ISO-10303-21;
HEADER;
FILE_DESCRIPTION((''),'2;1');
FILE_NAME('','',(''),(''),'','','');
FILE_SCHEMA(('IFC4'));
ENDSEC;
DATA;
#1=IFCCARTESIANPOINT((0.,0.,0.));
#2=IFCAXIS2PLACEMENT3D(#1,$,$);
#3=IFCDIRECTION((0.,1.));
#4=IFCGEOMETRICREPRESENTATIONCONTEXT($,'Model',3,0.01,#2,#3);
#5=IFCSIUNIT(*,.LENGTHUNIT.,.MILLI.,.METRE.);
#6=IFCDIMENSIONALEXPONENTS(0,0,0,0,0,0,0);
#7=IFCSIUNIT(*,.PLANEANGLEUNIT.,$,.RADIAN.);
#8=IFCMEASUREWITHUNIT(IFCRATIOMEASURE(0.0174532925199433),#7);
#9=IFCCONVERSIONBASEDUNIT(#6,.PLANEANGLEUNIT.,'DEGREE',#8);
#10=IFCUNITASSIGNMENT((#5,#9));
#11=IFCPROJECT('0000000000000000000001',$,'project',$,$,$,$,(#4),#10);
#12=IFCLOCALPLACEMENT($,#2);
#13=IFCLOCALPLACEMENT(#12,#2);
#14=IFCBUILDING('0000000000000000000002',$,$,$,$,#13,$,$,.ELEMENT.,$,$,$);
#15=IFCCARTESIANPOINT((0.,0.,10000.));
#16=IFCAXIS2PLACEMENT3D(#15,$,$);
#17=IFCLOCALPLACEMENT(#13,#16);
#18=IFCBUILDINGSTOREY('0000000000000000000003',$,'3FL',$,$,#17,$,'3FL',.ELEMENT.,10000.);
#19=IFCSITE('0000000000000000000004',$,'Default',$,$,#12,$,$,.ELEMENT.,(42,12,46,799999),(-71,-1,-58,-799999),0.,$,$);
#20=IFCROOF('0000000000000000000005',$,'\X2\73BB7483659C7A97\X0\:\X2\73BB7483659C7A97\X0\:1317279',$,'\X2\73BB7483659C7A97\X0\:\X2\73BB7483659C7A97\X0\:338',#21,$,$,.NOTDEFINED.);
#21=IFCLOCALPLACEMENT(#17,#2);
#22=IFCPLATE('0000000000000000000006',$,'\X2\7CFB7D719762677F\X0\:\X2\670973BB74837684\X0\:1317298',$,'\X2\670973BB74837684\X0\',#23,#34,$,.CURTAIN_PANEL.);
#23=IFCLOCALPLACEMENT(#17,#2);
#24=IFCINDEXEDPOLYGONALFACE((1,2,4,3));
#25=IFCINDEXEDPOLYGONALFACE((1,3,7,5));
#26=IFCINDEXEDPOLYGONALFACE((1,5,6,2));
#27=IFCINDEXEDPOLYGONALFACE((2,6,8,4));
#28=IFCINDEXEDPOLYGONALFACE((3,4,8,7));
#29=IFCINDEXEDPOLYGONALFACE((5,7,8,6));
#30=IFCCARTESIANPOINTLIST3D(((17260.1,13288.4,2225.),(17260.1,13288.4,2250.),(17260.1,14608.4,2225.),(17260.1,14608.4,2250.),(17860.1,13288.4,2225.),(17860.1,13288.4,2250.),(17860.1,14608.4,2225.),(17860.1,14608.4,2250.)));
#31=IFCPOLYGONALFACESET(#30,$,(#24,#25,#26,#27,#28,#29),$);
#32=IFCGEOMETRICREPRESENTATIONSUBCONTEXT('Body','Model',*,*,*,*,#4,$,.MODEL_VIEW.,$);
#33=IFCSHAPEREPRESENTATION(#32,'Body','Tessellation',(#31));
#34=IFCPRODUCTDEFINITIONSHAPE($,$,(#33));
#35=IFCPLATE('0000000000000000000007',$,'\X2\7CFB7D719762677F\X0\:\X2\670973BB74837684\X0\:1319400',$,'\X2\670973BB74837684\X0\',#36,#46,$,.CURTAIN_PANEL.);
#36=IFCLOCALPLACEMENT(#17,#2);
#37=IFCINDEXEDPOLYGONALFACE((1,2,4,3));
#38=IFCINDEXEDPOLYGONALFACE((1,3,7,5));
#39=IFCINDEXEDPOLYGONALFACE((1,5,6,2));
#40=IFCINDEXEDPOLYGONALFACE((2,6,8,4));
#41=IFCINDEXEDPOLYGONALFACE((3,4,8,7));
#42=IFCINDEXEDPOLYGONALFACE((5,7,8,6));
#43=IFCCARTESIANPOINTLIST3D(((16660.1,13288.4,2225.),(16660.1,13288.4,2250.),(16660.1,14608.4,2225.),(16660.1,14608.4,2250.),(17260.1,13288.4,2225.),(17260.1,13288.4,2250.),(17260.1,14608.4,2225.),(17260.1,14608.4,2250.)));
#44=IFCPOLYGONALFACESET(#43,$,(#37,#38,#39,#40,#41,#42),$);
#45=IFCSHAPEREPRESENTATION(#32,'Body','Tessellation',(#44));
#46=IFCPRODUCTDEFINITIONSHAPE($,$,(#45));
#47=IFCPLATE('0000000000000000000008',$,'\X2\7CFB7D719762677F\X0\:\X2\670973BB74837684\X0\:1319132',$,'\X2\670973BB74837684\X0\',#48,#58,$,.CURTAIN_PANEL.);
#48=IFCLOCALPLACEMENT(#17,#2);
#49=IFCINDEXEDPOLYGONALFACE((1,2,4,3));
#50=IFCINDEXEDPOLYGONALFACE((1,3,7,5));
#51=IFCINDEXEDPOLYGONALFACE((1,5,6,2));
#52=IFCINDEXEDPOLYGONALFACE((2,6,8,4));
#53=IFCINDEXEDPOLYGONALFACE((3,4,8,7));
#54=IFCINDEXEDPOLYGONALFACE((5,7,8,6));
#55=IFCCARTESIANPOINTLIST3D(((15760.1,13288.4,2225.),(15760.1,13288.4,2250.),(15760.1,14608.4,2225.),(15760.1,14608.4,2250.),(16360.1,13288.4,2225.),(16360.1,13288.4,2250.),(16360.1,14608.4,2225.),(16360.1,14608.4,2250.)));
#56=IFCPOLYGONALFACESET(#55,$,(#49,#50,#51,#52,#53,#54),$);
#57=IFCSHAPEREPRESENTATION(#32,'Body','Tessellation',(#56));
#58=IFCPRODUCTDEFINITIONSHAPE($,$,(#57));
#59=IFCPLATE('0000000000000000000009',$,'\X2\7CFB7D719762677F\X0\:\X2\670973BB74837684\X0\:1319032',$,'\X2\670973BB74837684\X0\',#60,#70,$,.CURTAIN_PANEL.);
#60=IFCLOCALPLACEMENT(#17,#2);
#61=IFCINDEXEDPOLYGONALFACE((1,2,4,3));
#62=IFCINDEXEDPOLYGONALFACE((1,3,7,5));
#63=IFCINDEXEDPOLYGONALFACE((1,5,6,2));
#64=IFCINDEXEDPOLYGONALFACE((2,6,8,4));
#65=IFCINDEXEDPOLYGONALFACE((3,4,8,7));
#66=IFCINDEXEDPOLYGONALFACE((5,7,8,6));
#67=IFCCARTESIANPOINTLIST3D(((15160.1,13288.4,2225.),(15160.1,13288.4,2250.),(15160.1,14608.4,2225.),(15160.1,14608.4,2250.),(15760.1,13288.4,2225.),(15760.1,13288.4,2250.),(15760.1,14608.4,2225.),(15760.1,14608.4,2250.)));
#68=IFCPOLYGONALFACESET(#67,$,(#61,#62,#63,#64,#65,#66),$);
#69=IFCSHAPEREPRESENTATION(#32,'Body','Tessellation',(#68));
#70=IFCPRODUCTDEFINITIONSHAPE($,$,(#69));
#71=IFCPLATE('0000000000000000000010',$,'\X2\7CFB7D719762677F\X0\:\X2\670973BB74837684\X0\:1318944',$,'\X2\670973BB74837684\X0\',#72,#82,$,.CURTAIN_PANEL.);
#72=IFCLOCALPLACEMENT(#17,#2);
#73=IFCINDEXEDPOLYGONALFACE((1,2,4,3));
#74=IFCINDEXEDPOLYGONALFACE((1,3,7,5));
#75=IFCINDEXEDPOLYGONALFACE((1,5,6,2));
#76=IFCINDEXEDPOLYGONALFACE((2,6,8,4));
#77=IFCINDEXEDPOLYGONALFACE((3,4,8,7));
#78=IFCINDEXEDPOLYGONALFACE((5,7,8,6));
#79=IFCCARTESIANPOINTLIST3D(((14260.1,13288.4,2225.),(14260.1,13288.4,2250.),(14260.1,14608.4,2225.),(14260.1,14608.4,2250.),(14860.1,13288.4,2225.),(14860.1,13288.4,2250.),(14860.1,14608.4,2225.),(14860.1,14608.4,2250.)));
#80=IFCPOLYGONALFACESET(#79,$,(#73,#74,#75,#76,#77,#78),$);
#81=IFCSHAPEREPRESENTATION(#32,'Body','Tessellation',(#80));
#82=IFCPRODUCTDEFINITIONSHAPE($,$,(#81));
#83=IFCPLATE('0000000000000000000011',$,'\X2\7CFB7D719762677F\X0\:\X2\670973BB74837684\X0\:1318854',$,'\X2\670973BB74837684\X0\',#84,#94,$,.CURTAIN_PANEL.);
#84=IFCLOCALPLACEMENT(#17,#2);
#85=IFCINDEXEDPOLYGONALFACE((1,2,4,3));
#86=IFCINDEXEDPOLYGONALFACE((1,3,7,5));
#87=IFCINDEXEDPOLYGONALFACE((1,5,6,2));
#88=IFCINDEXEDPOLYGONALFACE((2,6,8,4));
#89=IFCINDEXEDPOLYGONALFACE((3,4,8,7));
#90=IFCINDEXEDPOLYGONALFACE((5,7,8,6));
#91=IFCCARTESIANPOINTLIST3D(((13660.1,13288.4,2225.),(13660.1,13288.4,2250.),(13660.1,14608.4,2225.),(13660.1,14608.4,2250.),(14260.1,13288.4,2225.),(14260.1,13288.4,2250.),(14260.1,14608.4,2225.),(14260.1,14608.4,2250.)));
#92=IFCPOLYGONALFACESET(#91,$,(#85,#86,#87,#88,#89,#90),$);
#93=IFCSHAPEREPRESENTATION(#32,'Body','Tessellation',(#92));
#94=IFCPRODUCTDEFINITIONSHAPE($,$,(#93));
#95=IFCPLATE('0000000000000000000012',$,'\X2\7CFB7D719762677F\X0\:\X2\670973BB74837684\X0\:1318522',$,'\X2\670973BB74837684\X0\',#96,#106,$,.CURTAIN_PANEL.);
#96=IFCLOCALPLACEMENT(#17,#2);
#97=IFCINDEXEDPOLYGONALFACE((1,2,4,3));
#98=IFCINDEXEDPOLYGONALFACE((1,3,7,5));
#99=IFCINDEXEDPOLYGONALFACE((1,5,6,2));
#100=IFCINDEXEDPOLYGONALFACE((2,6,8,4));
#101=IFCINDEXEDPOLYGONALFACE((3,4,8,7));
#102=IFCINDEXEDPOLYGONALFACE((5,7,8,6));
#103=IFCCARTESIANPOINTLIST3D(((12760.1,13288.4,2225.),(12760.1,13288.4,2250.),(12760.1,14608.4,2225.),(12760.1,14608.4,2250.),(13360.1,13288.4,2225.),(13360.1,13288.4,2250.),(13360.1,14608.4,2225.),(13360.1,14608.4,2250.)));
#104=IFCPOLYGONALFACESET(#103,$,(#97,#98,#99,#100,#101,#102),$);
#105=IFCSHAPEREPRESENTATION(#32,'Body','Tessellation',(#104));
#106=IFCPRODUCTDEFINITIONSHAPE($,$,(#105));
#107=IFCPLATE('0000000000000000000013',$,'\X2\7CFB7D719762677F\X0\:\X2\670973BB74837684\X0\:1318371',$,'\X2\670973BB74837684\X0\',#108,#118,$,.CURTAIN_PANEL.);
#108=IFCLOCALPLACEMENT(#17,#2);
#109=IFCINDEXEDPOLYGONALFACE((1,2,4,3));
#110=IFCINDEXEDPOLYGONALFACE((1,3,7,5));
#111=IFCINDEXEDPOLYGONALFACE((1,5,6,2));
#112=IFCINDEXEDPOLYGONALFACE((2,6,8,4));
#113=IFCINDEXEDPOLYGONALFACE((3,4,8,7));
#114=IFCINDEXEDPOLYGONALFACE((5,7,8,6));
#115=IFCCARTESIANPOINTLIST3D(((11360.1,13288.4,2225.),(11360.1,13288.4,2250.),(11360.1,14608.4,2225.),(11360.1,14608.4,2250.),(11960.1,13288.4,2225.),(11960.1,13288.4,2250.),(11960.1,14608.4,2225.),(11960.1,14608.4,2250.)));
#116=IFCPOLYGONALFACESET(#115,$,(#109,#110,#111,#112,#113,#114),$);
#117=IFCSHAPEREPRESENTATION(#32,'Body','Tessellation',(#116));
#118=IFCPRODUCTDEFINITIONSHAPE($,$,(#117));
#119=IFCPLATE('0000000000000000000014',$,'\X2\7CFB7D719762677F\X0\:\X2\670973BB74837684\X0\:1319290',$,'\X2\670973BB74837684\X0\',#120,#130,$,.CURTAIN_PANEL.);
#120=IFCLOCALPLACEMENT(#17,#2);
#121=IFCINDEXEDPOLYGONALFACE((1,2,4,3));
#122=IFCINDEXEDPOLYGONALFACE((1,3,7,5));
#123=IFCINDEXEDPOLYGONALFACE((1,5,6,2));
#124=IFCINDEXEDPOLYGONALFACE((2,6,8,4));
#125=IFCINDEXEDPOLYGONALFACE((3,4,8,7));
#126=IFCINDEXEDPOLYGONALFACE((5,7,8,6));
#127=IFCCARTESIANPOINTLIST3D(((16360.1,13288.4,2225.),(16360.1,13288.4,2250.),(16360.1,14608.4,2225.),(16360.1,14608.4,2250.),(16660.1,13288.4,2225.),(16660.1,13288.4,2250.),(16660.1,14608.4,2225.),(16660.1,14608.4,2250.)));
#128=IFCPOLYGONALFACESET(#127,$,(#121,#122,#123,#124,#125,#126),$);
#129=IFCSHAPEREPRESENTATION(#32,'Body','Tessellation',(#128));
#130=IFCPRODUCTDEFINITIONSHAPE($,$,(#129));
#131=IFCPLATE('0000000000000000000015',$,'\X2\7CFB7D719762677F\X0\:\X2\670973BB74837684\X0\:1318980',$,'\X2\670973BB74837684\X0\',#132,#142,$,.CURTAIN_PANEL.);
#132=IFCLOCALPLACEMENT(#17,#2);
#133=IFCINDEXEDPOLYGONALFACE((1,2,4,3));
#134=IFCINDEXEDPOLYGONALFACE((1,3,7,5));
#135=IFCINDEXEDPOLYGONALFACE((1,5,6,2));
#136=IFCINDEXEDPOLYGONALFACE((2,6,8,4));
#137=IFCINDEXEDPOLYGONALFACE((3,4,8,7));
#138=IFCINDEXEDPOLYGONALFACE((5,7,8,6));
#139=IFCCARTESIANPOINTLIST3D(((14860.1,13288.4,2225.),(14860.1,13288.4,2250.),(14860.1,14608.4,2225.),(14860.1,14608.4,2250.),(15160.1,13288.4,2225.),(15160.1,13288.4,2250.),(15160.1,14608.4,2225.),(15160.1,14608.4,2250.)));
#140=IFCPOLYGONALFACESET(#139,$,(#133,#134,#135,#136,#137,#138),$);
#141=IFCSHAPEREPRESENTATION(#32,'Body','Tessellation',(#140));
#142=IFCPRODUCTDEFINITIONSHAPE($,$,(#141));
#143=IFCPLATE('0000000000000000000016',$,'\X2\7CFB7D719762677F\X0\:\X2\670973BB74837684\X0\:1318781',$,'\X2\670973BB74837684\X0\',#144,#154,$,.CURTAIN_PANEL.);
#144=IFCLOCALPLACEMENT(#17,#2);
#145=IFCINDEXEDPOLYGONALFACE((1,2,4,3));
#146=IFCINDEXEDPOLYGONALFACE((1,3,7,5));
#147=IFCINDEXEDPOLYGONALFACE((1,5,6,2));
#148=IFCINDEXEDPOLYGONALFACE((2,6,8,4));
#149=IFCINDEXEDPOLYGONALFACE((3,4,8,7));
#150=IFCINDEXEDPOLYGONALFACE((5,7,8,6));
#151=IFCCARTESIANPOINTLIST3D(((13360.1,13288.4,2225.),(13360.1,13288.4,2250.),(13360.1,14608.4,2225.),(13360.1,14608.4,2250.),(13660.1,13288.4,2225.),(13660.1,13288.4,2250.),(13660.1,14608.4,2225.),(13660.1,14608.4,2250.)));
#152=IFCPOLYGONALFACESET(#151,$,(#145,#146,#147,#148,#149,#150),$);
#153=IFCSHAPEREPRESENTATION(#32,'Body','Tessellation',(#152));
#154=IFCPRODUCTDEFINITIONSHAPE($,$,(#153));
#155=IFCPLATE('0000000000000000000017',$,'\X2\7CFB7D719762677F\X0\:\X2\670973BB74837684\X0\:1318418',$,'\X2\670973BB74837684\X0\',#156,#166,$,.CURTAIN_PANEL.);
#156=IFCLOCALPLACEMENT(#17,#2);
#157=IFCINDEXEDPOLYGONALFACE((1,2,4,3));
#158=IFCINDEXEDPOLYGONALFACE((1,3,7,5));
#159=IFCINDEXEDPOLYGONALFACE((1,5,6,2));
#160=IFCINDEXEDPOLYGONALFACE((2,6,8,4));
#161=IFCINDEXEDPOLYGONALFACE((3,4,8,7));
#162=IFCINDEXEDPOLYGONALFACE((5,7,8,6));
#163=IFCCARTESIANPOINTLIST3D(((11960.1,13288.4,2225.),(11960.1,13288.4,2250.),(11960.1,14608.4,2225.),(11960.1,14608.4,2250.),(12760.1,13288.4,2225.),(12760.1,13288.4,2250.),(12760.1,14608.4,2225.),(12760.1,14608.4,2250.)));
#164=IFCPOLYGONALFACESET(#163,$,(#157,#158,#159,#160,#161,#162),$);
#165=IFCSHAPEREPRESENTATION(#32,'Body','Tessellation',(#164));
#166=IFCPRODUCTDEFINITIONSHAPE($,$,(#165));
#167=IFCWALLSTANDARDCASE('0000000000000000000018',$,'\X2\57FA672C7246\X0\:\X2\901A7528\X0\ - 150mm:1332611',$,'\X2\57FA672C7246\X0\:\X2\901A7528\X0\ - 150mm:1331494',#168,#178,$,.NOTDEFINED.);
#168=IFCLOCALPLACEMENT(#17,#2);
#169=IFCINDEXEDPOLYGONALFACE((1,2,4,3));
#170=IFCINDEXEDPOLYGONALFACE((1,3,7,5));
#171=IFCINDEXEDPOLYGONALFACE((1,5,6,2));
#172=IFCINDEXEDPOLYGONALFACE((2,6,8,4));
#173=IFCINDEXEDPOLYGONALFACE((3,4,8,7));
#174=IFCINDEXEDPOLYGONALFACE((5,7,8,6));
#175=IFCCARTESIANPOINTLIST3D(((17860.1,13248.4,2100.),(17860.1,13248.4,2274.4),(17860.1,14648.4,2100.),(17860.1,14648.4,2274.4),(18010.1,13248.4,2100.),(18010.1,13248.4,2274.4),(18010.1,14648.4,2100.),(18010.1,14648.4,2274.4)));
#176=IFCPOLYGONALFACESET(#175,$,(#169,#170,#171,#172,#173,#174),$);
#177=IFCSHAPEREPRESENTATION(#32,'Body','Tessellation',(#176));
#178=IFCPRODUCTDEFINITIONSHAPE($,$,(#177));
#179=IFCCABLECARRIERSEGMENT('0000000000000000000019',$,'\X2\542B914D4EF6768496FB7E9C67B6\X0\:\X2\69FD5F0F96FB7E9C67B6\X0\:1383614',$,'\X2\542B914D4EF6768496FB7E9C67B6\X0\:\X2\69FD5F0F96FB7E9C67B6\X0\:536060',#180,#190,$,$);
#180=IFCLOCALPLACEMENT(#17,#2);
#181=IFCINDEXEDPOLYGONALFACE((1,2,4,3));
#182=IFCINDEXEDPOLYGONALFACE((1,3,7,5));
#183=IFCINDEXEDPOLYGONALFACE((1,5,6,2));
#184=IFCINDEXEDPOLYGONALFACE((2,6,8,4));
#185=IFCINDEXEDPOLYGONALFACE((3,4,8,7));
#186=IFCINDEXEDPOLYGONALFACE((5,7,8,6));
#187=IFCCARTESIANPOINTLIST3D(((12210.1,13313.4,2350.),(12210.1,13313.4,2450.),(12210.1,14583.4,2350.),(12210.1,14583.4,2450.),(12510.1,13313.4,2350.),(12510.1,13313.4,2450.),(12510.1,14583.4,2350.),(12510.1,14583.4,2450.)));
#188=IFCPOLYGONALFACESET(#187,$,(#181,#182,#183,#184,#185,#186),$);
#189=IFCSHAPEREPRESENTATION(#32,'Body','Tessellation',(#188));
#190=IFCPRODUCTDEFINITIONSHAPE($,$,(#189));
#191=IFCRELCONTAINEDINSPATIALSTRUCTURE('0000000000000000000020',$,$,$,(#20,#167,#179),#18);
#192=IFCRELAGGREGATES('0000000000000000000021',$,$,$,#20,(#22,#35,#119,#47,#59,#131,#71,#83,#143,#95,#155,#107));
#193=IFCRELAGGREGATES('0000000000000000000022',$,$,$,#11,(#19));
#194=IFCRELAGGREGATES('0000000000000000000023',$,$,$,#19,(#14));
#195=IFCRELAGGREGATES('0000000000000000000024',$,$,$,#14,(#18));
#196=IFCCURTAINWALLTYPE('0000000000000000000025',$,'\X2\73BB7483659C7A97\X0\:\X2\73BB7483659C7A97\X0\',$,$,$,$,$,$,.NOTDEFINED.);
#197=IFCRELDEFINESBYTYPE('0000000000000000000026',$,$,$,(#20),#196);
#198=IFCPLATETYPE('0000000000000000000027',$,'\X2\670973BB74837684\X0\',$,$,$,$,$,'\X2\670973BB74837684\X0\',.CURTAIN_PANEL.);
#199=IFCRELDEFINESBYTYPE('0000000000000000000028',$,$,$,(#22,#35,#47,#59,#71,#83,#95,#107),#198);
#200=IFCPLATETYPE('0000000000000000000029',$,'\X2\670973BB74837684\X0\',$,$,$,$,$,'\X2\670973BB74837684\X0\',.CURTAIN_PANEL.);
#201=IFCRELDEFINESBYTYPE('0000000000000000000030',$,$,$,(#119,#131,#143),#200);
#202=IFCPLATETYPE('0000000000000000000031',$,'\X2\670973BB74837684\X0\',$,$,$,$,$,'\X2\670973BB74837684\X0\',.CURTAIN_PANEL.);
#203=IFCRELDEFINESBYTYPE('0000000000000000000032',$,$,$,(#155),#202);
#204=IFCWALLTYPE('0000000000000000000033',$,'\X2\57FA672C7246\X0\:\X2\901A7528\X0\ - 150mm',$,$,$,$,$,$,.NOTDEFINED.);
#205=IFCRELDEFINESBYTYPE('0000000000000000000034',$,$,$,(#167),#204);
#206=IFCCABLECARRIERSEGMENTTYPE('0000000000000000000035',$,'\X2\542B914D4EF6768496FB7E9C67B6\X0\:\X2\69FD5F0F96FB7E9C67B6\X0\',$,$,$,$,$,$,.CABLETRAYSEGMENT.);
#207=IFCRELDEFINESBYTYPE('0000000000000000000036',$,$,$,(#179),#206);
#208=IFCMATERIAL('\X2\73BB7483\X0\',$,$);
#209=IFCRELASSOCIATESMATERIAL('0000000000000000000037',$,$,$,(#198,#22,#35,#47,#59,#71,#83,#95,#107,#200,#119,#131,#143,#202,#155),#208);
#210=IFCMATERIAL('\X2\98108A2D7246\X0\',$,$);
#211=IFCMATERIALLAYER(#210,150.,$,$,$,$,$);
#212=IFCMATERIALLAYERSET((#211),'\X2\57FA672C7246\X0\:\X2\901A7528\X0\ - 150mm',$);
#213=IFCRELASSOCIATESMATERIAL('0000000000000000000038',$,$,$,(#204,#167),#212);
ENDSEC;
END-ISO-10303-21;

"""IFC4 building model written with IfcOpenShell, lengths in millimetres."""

from ifc_helpers import new_model, entity, si_unit, converted_unit, direction, frame, frame_2d, origin, origin_2d_with_axis, place, context, subcontext, project, spatial, rectangle, extrude, source, transform, mapped, material, layer, layer_set, layer_usage, type_object, type_shapes, element, aggregate, save


model = new_model("IFC4")

# Units and contexts
model_context = context("Model", 3, precision=0.01, world=origin(), true_north=direction((0.0, 1.0)))
body_context = subcontext(model_context, "Body", "Model", "MODEL_VIEW")
ifc_project = project(units=[si_unit("LENGTHUNIT", "METRE", prefix="MILLI"), converted_unit("PLANEANGLEUNIT", "DEGREE", entity("IfcRatioMeasure", 0.0174532925199433), si_unit("PLANEANGLEUNIT", "RADIAN"), dimensions=[0, 0, 0, 0, 0, 0, 0])], contexts=[model_context])

# Site, building, storey
site_placement = place(None, origin())
site = spatial("IfcSite", under=ifc_project, at=site_placement, Name="Default", CompositionType="ELEMENT", RefLatitude=(42, 12, 46, 799999), RefLongitude=(-71, -1, -58, -799999), RefElevation=0.0)
building_placement = place(site_placement, origin())
building = spatial("IfcBuilding", under=site, at=building_placement, CompositionType="ELEMENT")
storey_placement = place(building_placement, frame((0.0, 0.0, 10000.0)))
storey = spatial("IfcBuildingStorey", under=building, at=storey_placement, Name="3FL", LongName="3FL", CompositionType="ELEMENT", Elevation=10000.0)

# Roof, plates
curtain_wall_type = type_object("IfcCurtainWallType", Name="玻璃斜窗:玻璃斜窗", PredefinedType="NOTDEFINED")
roof_placement = place(storey_placement, frame((0.0, 0.0, -10000.0)))
roof = element("IfcRoof", 1, at=roof_placement, inside=storey, type_object=curtain_wall_type, Name="玻璃斜窗:玻璃斜窗:1317279", ObjectType="玻璃斜窗:玻璃斜窗:338", PredefinedType="NOTDEFINED")
ifc_material_1 = material(Name="玻璃")
plate_type_1 = type_object("IfcPlateType", Name="有玻璃的", ElementType="有玻璃的", PredefinedType="CURTAIN_PANEL", material=ifc_material_1)
shared_shape_1 = source(origin(), body_context, "Body", "SweptSolid", [
    extrude(rectangle(XDim=25.0, YDim=600.0, at=origin_2d_with_axis()), frame((300.0, 12.5, 0.0), z_axis=(0.0, 0.0, 1.0), x_axis=(0.0, 1.0, 0.0)), (0.0, 0.0, 1.0), 1320.0),
])
type_shapes(plate_type_1, [shared_shape_1])
plate_1_placement = place(roof_placement, frame((17860.1, 14608.4, 12250.0), z_axis=(0.0, -1.0, 0.0), x_axis=(-1.0, 0.0, 0.0)))
plate_1 = element("IfcPlate", 2, at=plate_1_placement, type_object=plate_type_1, material=ifc_material_1, Name="系統面板:有玻璃的:1317298", ObjectType="有玻璃的", PredefinedType="CURTAIN_PANEL", context=body_context, shape_type="MappedRepresentation", body=[
    mapped(shared_shape_1, transform((0.0, 0.0, 0.0), scale=1.0)),
])
plate_2_placement = place(roof_placement, frame((17260.1, 14608.4, 12250.0), z_axis=(0.0, -1.0, 0.0), x_axis=(-1.0, 0.0, 0.0)))
plate_2 = element("IfcPlate", 3, at=plate_2_placement, type_object=plate_type_1, material=ifc_material_1, Name="系統面板:有玻璃的:1319400", ObjectType="有玻璃的", PredefinedType="CURTAIN_PANEL", context=body_context, shape_type="MappedRepresentation", body=[
    mapped(shared_shape_1, transform((0.0, 0.0, 0.0), scale=1.0)),
])
plate_3_placement = place(roof_placement, frame((16360.1, 14608.4, 12250.0), z_axis=(0.0, -1.0, 0.0), x_axis=(-1.0, 0.0, 0.0)))
plate_3 = element("IfcPlate", 4, at=plate_3_placement, type_object=plate_type_1, material=ifc_material_1, Name="系統面板:有玻璃的:1319132", ObjectType="有玻璃的", PredefinedType="CURTAIN_PANEL", context=body_context, shape_type="MappedRepresentation", body=[
    mapped(shared_shape_1, transform((0.0, 0.0, 0.0), scale=1.0)),
])
plate_4_placement = place(roof_placement, frame((15760.1, 14608.4, 12250.0), z_axis=(0.0, -1.0, 0.0), x_axis=(-1.0, 0.0, 0.0)))
plate_4 = element("IfcPlate", 5, at=plate_4_placement, type_object=plate_type_1, material=ifc_material_1, Name="系統面板:有玻璃的:1319032", ObjectType="有玻璃的", PredefinedType="CURTAIN_PANEL", context=body_context, shape_type="MappedRepresentation", body=[
    mapped(shared_shape_1, transform((0.0, 0.0, 0.0), scale=1.0)),
])
plate_5_placement = place(roof_placement, frame((14860.1, 14608.4, 12250.0), z_axis=(0.0, -1.0, 0.0), x_axis=(-1.0, 0.0, 0.0)))
plate_5 = element("IfcPlate", 6, at=plate_5_placement, type_object=plate_type_1, material=ifc_material_1, Name="系統面板:有玻璃的:1318944", ObjectType="有玻璃的", PredefinedType="CURTAIN_PANEL", context=body_context, shape_type="MappedRepresentation", body=[
    mapped(shared_shape_1, transform((0.0, 0.0, 0.0), scale=1.0)),
])
plate_6_placement = place(roof_placement, frame((14260.1, 14608.4, 12250.0), z_axis=(0.0, -1.0, 0.0), x_axis=(-1.0, 0.0, 0.0)))
plate_6 = element("IfcPlate", 7, at=plate_6_placement, type_object=plate_type_1, material=ifc_material_1, Name="系統面板:有玻璃的:1318854", ObjectType="有玻璃的", PredefinedType="CURTAIN_PANEL", context=body_context, shape_type="MappedRepresentation", body=[
    mapped(shared_shape_1, transform((0.0, 0.0, 0.0), scale=1.0)),
])
plate_7_placement = place(roof_placement, frame((13360.1, 14608.4, 12250.0), z_axis=(0.0, -1.0, 0.0), x_axis=(-1.0, 0.0, 0.0)))
plate_7 = element("IfcPlate", 8, at=plate_7_placement, type_object=plate_type_1, material=ifc_material_1, Name="系統面板:有玻璃的:1318522", ObjectType="有玻璃的", PredefinedType="CURTAIN_PANEL", context=body_context, shape_type="MappedRepresentation", body=[
    mapped(shared_shape_1, transform((0.0, 0.0, 0.0), scale=1.0)),
])
plate_8_placement = place(roof_placement, frame((11960.1, 14608.4, 12250.0), z_axis=(0.0, -1.0, 0.0), x_axis=(-1.0, 0.0, 0.0)))
plate_8 = element("IfcPlate", 9, at=plate_8_placement, type_object=plate_type_1, material=ifc_material_1, Name="系統面板:有玻璃的:1318371", ObjectType="有玻璃的", PredefinedType="CURTAIN_PANEL", context=body_context, shape_type="MappedRepresentation", body=[
    mapped(shared_shape_1, transform((0.0, 0.0, 0.0), scale=1.0)),
])
plate_type_2 = type_object("IfcPlateType", Name="有玻璃的", ElementType="有玻璃的", PredefinedType="CURTAIN_PANEL", material=ifc_material_1)
shared_shape_2 = source(origin(), body_context, "Body", "SweptSolid", [
    extrude(rectangle(XDim=25.0, YDim=300.0, at=origin_2d_with_axis()), frame((150.0, 12.5, 0.0), z_axis=(0.0, 0.0, 1.0), x_axis=(0.0, 1.0, 0.0)), (0.0, 0.0, 1.0), 1320.0),
])
type_shapes(plate_type_2, [shared_shape_2])
plate_9_placement = place(roof_placement, frame((16660.1, 14608.4, 12250.0), z_axis=(0.0, -1.0, 0.0), x_axis=(-1.0, 0.0, 0.0)))
plate_9 = element("IfcPlate", 10, at=plate_9_placement, type_object=plate_type_2, material=ifc_material_1, Name="系統面板:有玻璃的:1319290", ObjectType="有玻璃的", PredefinedType="CURTAIN_PANEL", context=body_context, shape_type="MappedRepresentation", body=[
    mapped(shared_shape_2, transform((0.0, 0.0, 0.0), scale=1.0)),
])
plate_10_placement = place(roof_placement, frame((15160.1, 14608.4, 12250.0), z_axis=(0.0, -1.0, 0.0), x_axis=(-1.0, 0.0, 0.0)))
plate_10 = element("IfcPlate", 11, at=plate_10_placement, type_object=plate_type_2, material=ifc_material_1, Name="系統面板:有玻璃的:1318980", ObjectType="有玻璃的", PredefinedType="CURTAIN_PANEL", context=body_context, shape_type="MappedRepresentation", body=[
    mapped(shared_shape_2, transform((0.0, 0.0, 0.0), scale=1.0)),
])
plate_11_placement = place(roof_placement, frame((13660.1, 14608.4, 12250.0), z_axis=(0.0, -1.0, 0.0), x_axis=(-1.0, 0.0, 0.0)))
plate_11 = element("IfcPlate", 12, at=plate_11_placement, type_object=plate_type_2, material=ifc_material_1, Name="系統面板:有玻璃的:1318781", ObjectType="有玻璃的", PredefinedType="CURTAIN_PANEL", context=body_context, shape_type="MappedRepresentation", body=[
    mapped(shared_shape_2, transform((0.0, 0.0, 0.0), scale=1.0)),
])
plate_type_3 = type_object("IfcPlateType", Name="有玻璃的", ElementType="有玻璃的", PredefinedType="CURTAIN_PANEL", material=ifc_material_1)
shared_shape_3 = source(origin(), body_context, "Body", "SweptSolid", [
    extrude(rectangle(XDim=25.0, YDim=800.0, at=origin_2d_with_axis()), frame((400.0, 12.5, 0.0), z_axis=(0.0, 0.0, 1.0), x_axis=(0.0, 1.0, 0.0)), (0.0, 0.0, 1.0), 1320.0),
])
type_shapes(plate_type_3, [shared_shape_3])
plate_12_placement = place(roof_placement, frame((12760.1, 14608.4, 12250.0), z_axis=(0.0, -1.0, 0.0), x_axis=(-1.0, 0.0, 0.0)))
plate_12 = element("IfcPlate", 13, at=plate_12_placement, type_object=plate_type_3, material=ifc_material_1, Name="系統面板:有玻璃的:1318418", ObjectType="有玻璃的", PredefinedType="CURTAIN_PANEL", context=body_context, shape_type="MappedRepresentation", body=[
    mapped(shared_shape_3, transform((0.0, 0.0, 0.0), scale=1.0)),
])
aggregate(roof, [plate_1, plate_2, plate_9, plate_3, plate_4, plate_10, plate_5, plate_6, plate_11, plate_7, plate_12, plate_8])

# Wall, opening
ifc_material_2 = material(Name="預設牆")
ifc_layer = layer(ifc_material_2, 150.0)
ifc_layer_set = layer_set([ifc_layer], Name="基本牆:通用 - 150mm")
ifc_layer_usage = layer_usage(ifc_layer_set, "AXIS2", "POSITIVE", -75.0)
wall_type = type_object("IfcWallType", Name="基本牆:通用 - 150mm", PredefinedType="NOTDEFINED", material=ifc_layer_set)
wall_placement = place(storey_placement, frame((17935.1, 14648.4, 2100.0), z_axis=(0.0, 0.0, 1.0), x_axis=(0.0, -1.0, 0.0)))
wall = element("IfcWallStandardCase", 14, at=wall_placement, inside=storey, type_object=wall_type, material=ifc_layer_usage, Name="基本牆:通用 - 150mm:1332611", ObjectType="基本牆:通用 - 150mm:1331494", PredefinedType="NOTDEFINED", context=body_context, shape_type="SweptSolid", body=[
    extrude(rectangle(XDim=1400.0, YDim=150.0, at=frame_2d((700.0, 0.0), x_axis=(-1.0, 0.0))), origin(), (0.0, 0.0, 1.0), 174.4),
])
opening_placement = place(wall_placement, frame((0.0, -75.0, -2100.0)))
element("IfcOpeningElement", 15, at=opening_placement, cuts=wall, ObjectType="Opening", PredefinedType="OPENING", context=body_context, shape_type="SweptSolid", body=[
    extrude(rectangle(XDim=2100.0, YDim=1400.0, at=frame_2d((1050.0, 700.0), x_axis=(1.0, 0.0))), frame((0.0, 0.0, 0.0), z_axis=(0.0, 1.0, 0.0), x_axis=(0.0, 0.0, 1.0)), (0.0, 0.0, 1.0), 150.0),
])

# Cable carrier segment
cable_carrier_segment_type_1 = type_object("IfcCableCarrierSegmentType", Name="含配件的電纜架:槽式電纜架", PredefinedType="CABLETRAYSEGMENT")
cable_carrier_segment_1_placement = place(storey_placement, frame((12210.1, 13313.4, 2350.0)))
element("IfcCableCarrierSegment", 16, at=cable_carrier_segment_1_placement, inside=storey, type_object=cable_carrier_segment_type_1, Name="含配件的電纜架:槽式電纜架:1383614", ObjectType="含配件的電纜架:槽式電纜架:536060", context=body_context, shape_type="SweptSolid", body=[
    extrude(rectangle(XDim=1270.0, YDim=300.0, at=frame_2d((0.0, 0.0), x_axis=(1.0, 0.0))), frame((150.0, 635.0, 0.0), z_axis=(0.0, 0.0, 1.0), x_axis=(0.0, -1.0, 0.0)), (0.0, 0.0, 1.0), 100.0),
])

save(model, "model.ifc")
